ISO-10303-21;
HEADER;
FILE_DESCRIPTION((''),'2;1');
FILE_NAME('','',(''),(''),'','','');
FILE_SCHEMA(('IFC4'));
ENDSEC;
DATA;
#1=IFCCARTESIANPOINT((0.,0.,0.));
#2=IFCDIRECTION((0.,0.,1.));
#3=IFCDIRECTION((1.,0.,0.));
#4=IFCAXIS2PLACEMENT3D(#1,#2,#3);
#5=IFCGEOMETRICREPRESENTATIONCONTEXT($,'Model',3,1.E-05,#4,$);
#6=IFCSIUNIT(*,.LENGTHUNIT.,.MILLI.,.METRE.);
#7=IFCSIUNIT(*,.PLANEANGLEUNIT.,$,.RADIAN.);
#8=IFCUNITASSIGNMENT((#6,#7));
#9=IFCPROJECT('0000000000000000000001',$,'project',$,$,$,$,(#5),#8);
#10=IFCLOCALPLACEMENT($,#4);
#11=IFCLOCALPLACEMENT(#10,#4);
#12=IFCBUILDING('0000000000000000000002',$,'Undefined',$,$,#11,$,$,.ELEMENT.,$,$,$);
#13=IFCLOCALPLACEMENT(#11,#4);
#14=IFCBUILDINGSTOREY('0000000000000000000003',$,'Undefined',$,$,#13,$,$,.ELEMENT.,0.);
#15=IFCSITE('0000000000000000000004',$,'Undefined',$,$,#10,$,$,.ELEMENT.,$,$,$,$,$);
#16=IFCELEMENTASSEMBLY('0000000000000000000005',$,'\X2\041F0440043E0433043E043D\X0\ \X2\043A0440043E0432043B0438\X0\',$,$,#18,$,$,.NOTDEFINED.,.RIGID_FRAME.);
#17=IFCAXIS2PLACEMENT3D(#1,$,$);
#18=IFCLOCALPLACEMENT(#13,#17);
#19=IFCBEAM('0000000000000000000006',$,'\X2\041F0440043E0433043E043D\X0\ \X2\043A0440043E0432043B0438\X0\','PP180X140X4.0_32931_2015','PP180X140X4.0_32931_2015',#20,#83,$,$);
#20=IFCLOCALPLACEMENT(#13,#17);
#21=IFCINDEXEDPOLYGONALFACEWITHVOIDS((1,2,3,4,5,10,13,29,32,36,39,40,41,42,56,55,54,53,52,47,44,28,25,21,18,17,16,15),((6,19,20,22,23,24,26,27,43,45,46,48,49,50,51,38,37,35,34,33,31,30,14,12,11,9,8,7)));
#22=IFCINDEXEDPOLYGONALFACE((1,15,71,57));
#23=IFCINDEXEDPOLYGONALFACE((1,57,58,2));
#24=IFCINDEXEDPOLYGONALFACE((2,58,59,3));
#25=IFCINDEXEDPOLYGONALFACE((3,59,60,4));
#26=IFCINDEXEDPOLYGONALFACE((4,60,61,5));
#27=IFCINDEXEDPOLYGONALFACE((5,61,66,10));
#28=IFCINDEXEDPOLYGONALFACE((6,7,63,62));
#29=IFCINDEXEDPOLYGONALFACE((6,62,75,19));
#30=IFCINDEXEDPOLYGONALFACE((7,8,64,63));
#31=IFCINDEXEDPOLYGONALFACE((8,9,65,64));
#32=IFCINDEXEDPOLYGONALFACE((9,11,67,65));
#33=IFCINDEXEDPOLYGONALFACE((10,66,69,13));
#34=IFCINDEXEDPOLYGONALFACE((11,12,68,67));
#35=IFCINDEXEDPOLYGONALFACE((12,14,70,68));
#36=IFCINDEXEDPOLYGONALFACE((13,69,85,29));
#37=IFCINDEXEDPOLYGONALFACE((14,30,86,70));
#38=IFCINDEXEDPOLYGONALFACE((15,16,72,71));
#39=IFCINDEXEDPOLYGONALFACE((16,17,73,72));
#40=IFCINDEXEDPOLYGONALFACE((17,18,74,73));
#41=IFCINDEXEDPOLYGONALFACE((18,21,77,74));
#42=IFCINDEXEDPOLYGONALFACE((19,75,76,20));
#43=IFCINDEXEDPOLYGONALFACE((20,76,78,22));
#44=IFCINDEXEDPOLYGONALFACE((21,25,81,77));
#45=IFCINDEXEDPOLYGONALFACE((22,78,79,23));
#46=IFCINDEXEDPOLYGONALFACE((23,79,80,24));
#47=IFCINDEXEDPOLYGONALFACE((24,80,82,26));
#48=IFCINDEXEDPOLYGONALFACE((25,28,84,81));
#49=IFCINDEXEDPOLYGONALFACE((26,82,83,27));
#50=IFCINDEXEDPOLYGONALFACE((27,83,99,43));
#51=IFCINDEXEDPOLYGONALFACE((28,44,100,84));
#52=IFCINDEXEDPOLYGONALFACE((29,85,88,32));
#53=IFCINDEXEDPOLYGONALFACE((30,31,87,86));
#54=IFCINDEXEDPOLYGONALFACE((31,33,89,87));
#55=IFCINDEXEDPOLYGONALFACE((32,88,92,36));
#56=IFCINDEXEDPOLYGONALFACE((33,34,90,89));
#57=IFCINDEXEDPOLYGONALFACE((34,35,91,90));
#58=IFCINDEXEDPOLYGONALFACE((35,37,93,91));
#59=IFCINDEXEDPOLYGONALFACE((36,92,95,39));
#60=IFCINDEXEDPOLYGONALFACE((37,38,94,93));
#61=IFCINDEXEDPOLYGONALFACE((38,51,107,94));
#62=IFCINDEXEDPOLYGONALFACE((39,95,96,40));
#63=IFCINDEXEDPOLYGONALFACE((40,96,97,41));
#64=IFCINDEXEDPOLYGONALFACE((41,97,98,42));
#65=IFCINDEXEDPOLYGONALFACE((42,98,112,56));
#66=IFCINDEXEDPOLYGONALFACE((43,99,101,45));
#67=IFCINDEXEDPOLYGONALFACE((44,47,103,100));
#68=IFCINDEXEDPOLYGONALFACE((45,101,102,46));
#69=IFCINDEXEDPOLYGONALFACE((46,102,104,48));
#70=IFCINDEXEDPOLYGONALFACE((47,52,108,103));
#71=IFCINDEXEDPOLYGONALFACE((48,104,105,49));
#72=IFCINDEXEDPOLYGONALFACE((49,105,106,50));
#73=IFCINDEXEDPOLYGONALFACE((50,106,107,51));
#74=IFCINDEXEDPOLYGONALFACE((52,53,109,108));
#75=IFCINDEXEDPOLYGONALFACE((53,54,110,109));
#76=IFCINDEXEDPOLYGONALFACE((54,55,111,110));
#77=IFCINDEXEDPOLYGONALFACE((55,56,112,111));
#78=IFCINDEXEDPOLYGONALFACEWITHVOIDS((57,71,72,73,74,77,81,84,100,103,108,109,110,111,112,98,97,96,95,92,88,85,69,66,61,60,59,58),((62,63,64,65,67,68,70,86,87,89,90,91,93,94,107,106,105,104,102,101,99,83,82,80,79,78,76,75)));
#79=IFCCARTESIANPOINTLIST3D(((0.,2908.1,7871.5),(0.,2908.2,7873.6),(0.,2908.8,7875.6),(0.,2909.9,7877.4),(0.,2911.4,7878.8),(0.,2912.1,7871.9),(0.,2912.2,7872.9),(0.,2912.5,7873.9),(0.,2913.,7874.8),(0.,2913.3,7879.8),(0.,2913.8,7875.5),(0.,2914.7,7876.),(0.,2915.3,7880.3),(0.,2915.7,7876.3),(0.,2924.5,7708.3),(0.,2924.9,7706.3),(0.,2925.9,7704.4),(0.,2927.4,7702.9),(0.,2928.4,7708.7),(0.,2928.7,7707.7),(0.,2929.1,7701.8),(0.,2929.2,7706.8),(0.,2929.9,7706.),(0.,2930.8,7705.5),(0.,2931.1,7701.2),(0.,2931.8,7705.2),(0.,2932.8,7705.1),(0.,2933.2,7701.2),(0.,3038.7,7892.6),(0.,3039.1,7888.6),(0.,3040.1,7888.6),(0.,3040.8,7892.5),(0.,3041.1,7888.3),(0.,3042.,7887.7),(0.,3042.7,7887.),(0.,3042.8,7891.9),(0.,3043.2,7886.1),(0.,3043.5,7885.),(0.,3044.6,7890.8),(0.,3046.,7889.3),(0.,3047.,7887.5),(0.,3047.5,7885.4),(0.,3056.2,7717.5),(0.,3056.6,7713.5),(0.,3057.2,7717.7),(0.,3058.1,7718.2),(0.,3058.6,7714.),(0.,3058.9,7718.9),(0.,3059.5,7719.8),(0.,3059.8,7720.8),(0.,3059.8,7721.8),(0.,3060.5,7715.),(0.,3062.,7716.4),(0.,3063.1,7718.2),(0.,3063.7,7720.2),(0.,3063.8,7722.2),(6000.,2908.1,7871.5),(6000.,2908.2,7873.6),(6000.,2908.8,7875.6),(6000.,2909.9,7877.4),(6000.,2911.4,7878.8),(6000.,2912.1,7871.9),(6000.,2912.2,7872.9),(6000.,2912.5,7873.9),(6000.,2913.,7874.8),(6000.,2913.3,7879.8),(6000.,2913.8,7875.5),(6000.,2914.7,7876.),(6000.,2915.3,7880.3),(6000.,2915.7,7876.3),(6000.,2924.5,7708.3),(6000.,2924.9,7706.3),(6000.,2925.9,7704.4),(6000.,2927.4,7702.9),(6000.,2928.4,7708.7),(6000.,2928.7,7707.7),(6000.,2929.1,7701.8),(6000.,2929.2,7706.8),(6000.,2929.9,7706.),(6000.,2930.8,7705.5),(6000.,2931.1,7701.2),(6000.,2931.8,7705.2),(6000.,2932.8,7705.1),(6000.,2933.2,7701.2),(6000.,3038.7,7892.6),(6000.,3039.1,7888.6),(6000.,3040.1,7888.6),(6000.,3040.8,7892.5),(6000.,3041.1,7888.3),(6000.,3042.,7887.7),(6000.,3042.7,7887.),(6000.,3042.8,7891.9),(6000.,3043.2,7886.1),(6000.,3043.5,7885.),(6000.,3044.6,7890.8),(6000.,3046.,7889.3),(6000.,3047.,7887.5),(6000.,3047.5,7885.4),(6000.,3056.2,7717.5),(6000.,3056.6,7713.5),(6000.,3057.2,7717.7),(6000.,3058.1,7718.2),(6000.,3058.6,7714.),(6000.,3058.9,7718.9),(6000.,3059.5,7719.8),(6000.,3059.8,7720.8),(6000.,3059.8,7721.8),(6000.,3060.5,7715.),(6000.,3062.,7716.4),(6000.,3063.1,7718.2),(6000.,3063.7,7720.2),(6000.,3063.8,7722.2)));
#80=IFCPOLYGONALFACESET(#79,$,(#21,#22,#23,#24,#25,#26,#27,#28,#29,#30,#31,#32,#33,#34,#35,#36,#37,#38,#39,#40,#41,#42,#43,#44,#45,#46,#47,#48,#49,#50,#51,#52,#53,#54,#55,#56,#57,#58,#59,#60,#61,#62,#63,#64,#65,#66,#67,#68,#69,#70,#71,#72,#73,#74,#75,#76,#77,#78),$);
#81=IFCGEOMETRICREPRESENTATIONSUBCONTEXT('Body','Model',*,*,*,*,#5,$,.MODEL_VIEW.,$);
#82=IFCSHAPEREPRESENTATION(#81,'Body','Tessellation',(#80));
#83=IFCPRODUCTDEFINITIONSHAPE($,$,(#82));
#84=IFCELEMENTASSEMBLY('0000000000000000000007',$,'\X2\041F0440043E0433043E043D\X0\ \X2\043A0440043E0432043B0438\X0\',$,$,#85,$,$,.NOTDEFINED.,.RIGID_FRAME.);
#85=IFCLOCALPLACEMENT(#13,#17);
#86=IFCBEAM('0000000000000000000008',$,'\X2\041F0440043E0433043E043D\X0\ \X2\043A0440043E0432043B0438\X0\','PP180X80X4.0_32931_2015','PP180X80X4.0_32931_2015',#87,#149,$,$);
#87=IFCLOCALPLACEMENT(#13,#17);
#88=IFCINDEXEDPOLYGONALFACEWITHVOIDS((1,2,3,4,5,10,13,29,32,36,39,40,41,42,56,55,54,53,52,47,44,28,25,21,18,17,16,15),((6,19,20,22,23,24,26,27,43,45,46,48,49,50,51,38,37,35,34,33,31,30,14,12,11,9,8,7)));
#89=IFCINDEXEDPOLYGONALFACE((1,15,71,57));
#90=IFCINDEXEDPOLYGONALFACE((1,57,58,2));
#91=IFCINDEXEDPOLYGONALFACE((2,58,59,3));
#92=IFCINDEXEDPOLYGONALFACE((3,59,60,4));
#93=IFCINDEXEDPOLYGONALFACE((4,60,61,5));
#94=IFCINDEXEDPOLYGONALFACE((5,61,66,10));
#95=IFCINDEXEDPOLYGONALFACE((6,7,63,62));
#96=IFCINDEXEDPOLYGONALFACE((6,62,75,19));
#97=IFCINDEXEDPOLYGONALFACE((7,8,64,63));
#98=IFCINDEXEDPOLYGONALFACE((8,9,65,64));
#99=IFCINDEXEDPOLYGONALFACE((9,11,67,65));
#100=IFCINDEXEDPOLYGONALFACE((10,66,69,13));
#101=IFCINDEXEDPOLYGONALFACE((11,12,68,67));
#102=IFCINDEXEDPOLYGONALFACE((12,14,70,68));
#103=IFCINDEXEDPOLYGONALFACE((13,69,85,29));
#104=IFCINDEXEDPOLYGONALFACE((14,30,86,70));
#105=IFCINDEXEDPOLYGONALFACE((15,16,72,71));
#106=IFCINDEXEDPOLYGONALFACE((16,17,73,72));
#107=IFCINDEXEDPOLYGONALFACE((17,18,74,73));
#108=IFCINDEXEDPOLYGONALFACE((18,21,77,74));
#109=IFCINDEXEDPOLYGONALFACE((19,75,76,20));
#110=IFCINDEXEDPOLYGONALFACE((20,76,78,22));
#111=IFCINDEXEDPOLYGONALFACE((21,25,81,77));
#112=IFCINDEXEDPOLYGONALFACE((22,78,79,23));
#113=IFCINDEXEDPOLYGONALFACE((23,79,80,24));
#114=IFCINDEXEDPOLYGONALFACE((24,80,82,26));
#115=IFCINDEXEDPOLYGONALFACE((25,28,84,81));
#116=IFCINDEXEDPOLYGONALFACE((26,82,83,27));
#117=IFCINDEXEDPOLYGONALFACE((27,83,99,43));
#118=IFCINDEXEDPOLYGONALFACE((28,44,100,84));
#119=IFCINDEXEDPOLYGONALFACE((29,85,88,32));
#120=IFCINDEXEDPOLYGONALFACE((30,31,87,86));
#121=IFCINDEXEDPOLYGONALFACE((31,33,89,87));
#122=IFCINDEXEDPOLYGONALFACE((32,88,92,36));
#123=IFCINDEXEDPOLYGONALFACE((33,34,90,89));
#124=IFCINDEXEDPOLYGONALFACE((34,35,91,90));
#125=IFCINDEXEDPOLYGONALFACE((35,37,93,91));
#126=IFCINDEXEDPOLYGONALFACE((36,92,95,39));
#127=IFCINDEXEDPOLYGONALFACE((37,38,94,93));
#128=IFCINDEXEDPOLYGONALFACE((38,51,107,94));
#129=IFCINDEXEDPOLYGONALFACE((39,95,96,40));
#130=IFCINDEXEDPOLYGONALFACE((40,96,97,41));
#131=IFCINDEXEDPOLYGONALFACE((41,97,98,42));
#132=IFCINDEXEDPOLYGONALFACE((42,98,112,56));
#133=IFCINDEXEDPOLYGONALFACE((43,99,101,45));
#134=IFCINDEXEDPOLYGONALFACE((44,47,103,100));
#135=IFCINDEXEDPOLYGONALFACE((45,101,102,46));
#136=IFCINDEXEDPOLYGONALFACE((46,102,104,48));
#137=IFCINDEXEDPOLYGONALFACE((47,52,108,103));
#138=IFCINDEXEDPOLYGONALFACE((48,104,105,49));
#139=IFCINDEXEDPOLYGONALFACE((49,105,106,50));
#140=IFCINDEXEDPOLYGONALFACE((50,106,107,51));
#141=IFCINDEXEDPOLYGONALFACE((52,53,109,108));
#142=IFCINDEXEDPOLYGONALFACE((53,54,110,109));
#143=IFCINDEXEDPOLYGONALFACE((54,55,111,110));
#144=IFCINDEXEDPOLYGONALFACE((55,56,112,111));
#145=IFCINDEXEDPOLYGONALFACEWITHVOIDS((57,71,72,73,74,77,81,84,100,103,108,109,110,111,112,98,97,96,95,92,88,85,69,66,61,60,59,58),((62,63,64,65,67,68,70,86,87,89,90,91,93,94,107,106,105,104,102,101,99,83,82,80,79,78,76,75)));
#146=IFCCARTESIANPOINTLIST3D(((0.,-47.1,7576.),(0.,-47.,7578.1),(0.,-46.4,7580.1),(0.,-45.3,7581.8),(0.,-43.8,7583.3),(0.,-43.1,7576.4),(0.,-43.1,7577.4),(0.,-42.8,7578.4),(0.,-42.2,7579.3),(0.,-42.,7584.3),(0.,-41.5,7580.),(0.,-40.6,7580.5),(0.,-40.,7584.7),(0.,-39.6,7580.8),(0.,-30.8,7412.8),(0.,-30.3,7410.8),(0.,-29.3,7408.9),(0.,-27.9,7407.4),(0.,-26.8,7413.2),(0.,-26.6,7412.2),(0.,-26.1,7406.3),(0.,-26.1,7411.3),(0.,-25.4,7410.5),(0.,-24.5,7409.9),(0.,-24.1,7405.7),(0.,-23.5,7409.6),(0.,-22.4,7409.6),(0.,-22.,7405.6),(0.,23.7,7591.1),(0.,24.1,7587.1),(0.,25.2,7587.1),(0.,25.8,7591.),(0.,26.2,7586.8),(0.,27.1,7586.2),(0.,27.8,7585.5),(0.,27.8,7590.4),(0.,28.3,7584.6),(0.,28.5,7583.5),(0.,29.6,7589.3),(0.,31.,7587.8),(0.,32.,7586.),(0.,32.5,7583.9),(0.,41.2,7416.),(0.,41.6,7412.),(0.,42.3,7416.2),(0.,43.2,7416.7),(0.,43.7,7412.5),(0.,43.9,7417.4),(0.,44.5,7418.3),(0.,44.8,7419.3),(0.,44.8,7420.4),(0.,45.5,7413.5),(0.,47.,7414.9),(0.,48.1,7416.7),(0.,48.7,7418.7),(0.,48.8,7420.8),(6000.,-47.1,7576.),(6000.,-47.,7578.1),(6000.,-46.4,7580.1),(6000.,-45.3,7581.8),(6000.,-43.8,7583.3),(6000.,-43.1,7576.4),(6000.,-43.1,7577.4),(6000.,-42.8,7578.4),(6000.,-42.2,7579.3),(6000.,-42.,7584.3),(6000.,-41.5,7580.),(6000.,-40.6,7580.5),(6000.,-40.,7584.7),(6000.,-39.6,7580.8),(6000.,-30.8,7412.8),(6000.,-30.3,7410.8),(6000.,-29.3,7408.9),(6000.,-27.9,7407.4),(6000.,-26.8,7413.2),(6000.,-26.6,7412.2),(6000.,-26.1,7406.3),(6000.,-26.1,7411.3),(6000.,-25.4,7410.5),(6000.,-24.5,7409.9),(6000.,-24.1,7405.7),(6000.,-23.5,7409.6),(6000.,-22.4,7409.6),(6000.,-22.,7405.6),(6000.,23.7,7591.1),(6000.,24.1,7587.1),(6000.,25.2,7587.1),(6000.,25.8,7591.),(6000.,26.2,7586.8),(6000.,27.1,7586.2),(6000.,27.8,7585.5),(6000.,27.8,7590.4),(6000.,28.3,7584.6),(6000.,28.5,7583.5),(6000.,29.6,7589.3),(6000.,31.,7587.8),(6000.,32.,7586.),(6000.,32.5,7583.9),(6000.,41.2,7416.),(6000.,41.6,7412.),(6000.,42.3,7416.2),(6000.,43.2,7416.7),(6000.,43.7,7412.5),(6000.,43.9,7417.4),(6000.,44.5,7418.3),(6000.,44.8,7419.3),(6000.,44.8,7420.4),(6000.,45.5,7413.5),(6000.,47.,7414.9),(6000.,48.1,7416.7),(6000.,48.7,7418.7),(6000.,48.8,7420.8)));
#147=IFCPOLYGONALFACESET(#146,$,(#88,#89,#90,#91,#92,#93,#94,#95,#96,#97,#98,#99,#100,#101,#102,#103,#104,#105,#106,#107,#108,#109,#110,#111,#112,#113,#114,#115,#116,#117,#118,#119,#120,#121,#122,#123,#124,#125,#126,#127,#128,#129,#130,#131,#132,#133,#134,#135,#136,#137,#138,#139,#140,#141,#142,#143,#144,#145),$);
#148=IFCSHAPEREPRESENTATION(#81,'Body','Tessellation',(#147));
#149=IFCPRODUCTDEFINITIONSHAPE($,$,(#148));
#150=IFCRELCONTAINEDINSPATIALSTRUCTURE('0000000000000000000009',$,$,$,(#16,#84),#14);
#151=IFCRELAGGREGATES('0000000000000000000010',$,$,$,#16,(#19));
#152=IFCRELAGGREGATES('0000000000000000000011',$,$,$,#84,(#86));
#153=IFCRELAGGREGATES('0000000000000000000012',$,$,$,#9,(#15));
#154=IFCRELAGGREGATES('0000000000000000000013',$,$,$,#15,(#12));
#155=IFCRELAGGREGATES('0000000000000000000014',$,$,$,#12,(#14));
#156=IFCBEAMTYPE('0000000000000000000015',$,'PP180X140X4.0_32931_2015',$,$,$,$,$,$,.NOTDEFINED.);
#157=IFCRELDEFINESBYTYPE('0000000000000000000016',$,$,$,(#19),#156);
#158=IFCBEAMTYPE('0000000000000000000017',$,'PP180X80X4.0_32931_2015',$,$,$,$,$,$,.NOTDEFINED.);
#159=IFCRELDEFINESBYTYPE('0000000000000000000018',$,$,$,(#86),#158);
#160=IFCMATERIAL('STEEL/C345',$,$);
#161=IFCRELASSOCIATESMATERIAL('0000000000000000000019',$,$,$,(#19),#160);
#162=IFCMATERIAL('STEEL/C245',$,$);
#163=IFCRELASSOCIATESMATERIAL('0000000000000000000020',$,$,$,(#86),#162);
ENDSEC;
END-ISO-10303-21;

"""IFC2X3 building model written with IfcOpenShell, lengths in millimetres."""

from ifc_helpers import new_model, si_unit, frame, origin_with_axes, origin_2d_with_axis, place, context, subcontext, project, spatial, hollow_rectangle, extrude, material, type_object, element, aggregate, save


model = new_model("IFC2X3")

# Units and contexts
model_context = context("Model", 3, precision=1e-05, world=origin_with_axes())
body_context = subcontext(model_context, "Body", "Model", "MODEL_VIEW")
ifc_project = project(units=[si_unit("LENGTHUNIT", "METRE", prefix="MILLI"), si_unit("PLANEANGLEUNIT", "RADIAN")], contexts=[model_context])

# Site, building, storey
site_placement = place(None, origin_with_axes())
site = spatial("IfcSite", under=ifc_project, at=site_placement, Name="Undefined", CompositionType="ELEMENT")
building_placement = place(site_placement, origin_with_axes())
building = spatial("IfcBuilding", under=site, at=building_placement, Name="Undefined", CompositionType="ELEMENT")
storey_placement = place(building_placement, origin_with_axes())
storey = spatial("IfcBuildingStorey", under=building, at=storey_placement, Name="Undefined", CompositionType="ELEMENT", Elevation=0.0)

# Shared definitions
ifc_material_1 = material(Name="STEEL/C345")

# Shared definitions
ifc_material_2 = material(Name="STEEL/C245")

# Element assemblies, beams
assembly_1_placement = place(storey_placement, origin_with_axes())
assembly_1 = element("IfcElementAssembly", 1, at=assembly_1_placement, inside=storey, Name="Прогон кровли", AssemblyPlace="NOTDEFINED", PredefinedType="RIGID_FRAME")
beam_type_1 = type_object("IfcBeamType", Name="PP180X140X4.0_32931_2015", PredefinedType="NOTDEFINED")
beam_1_placement = place(assembly_1_placement, frame((0.0, 2986.0, 7796.9), z_axis=(0.0, -0.099504, 0.995037), x_axis=(1.0, 0.0, 0.0)))
beam_1 = element("IfcBeam", 2, at=beam_1_placement, type_object=beam_type_1, material=ifc_material_1, Name="Прогон кровли", Description="PP180X140X4.0_32931_2015", ObjectType="PP180X140X4.0_32931_2015", context=body_context, shape_type="SweptSolid", body=[
    extrude(hollow_rectangle(XDim=140.0, YDim=180.0, WallThickness=4.0, InnerFilletRadius=4.0, OuterFilletRadius=8.0, at=origin_2d_with_axis()), frame((6000.0, 0.0, 0.0), z_axis=(-1.0, 0.0, 0.0), x_axis=(0.0, -1.0, 0.0)), (0.0, 0.0, 1.0), 6000.0),
])
aggregate(assembly_1, [beam_1])
assembly_2_placement = place(storey_placement, origin_with_axes())
assembly_2 = element("IfcElementAssembly", 3, at=assembly_2_placement, inside=storey, Name="Прогон кровли", AssemblyPlace="NOTDEFINED", PredefinedType="RIGID_FRAME")
beam_type_2 = type_object("IfcBeamType", Name="PP180X80X4.0_32931_2015", PredefinedType="NOTDEFINED")
beam_2_placement = place(assembly_2_placement, frame((0.0, 0.8, 7498.4), z_axis=(0.0, -0.099504, 0.995037), x_axis=(1.0, 0.0, 0.0)))
beam_2 = element("IfcBeam", 4, at=beam_2_placement, type_object=beam_type_2, material=ifc_material_2, Name="Прогон кровли", Description="PP180X80X4.0_32931_2015", ObjectType="PP180X80X4.0_32931_2015", context=body_context, shape_type="SweptSolid", body=[
    extrude(hollow_rectangle(XDim=80.0, YDim=180.0, WallThickness=4.0, InnerFilletRadius=4.0, OuterFilletRadius=8.0, at=origin_2d_with_axis()), frame((6000.0, 0.0, 0.0), z_axis=(-1.0, 0.0, 0.0), x_axis=(0.0, -1.0, 0.0)), (0.0, 0.0, 1.0), 6000.0),
])
aggregate(assembly_2, [beam_2])

save(model, "model.ifc")
